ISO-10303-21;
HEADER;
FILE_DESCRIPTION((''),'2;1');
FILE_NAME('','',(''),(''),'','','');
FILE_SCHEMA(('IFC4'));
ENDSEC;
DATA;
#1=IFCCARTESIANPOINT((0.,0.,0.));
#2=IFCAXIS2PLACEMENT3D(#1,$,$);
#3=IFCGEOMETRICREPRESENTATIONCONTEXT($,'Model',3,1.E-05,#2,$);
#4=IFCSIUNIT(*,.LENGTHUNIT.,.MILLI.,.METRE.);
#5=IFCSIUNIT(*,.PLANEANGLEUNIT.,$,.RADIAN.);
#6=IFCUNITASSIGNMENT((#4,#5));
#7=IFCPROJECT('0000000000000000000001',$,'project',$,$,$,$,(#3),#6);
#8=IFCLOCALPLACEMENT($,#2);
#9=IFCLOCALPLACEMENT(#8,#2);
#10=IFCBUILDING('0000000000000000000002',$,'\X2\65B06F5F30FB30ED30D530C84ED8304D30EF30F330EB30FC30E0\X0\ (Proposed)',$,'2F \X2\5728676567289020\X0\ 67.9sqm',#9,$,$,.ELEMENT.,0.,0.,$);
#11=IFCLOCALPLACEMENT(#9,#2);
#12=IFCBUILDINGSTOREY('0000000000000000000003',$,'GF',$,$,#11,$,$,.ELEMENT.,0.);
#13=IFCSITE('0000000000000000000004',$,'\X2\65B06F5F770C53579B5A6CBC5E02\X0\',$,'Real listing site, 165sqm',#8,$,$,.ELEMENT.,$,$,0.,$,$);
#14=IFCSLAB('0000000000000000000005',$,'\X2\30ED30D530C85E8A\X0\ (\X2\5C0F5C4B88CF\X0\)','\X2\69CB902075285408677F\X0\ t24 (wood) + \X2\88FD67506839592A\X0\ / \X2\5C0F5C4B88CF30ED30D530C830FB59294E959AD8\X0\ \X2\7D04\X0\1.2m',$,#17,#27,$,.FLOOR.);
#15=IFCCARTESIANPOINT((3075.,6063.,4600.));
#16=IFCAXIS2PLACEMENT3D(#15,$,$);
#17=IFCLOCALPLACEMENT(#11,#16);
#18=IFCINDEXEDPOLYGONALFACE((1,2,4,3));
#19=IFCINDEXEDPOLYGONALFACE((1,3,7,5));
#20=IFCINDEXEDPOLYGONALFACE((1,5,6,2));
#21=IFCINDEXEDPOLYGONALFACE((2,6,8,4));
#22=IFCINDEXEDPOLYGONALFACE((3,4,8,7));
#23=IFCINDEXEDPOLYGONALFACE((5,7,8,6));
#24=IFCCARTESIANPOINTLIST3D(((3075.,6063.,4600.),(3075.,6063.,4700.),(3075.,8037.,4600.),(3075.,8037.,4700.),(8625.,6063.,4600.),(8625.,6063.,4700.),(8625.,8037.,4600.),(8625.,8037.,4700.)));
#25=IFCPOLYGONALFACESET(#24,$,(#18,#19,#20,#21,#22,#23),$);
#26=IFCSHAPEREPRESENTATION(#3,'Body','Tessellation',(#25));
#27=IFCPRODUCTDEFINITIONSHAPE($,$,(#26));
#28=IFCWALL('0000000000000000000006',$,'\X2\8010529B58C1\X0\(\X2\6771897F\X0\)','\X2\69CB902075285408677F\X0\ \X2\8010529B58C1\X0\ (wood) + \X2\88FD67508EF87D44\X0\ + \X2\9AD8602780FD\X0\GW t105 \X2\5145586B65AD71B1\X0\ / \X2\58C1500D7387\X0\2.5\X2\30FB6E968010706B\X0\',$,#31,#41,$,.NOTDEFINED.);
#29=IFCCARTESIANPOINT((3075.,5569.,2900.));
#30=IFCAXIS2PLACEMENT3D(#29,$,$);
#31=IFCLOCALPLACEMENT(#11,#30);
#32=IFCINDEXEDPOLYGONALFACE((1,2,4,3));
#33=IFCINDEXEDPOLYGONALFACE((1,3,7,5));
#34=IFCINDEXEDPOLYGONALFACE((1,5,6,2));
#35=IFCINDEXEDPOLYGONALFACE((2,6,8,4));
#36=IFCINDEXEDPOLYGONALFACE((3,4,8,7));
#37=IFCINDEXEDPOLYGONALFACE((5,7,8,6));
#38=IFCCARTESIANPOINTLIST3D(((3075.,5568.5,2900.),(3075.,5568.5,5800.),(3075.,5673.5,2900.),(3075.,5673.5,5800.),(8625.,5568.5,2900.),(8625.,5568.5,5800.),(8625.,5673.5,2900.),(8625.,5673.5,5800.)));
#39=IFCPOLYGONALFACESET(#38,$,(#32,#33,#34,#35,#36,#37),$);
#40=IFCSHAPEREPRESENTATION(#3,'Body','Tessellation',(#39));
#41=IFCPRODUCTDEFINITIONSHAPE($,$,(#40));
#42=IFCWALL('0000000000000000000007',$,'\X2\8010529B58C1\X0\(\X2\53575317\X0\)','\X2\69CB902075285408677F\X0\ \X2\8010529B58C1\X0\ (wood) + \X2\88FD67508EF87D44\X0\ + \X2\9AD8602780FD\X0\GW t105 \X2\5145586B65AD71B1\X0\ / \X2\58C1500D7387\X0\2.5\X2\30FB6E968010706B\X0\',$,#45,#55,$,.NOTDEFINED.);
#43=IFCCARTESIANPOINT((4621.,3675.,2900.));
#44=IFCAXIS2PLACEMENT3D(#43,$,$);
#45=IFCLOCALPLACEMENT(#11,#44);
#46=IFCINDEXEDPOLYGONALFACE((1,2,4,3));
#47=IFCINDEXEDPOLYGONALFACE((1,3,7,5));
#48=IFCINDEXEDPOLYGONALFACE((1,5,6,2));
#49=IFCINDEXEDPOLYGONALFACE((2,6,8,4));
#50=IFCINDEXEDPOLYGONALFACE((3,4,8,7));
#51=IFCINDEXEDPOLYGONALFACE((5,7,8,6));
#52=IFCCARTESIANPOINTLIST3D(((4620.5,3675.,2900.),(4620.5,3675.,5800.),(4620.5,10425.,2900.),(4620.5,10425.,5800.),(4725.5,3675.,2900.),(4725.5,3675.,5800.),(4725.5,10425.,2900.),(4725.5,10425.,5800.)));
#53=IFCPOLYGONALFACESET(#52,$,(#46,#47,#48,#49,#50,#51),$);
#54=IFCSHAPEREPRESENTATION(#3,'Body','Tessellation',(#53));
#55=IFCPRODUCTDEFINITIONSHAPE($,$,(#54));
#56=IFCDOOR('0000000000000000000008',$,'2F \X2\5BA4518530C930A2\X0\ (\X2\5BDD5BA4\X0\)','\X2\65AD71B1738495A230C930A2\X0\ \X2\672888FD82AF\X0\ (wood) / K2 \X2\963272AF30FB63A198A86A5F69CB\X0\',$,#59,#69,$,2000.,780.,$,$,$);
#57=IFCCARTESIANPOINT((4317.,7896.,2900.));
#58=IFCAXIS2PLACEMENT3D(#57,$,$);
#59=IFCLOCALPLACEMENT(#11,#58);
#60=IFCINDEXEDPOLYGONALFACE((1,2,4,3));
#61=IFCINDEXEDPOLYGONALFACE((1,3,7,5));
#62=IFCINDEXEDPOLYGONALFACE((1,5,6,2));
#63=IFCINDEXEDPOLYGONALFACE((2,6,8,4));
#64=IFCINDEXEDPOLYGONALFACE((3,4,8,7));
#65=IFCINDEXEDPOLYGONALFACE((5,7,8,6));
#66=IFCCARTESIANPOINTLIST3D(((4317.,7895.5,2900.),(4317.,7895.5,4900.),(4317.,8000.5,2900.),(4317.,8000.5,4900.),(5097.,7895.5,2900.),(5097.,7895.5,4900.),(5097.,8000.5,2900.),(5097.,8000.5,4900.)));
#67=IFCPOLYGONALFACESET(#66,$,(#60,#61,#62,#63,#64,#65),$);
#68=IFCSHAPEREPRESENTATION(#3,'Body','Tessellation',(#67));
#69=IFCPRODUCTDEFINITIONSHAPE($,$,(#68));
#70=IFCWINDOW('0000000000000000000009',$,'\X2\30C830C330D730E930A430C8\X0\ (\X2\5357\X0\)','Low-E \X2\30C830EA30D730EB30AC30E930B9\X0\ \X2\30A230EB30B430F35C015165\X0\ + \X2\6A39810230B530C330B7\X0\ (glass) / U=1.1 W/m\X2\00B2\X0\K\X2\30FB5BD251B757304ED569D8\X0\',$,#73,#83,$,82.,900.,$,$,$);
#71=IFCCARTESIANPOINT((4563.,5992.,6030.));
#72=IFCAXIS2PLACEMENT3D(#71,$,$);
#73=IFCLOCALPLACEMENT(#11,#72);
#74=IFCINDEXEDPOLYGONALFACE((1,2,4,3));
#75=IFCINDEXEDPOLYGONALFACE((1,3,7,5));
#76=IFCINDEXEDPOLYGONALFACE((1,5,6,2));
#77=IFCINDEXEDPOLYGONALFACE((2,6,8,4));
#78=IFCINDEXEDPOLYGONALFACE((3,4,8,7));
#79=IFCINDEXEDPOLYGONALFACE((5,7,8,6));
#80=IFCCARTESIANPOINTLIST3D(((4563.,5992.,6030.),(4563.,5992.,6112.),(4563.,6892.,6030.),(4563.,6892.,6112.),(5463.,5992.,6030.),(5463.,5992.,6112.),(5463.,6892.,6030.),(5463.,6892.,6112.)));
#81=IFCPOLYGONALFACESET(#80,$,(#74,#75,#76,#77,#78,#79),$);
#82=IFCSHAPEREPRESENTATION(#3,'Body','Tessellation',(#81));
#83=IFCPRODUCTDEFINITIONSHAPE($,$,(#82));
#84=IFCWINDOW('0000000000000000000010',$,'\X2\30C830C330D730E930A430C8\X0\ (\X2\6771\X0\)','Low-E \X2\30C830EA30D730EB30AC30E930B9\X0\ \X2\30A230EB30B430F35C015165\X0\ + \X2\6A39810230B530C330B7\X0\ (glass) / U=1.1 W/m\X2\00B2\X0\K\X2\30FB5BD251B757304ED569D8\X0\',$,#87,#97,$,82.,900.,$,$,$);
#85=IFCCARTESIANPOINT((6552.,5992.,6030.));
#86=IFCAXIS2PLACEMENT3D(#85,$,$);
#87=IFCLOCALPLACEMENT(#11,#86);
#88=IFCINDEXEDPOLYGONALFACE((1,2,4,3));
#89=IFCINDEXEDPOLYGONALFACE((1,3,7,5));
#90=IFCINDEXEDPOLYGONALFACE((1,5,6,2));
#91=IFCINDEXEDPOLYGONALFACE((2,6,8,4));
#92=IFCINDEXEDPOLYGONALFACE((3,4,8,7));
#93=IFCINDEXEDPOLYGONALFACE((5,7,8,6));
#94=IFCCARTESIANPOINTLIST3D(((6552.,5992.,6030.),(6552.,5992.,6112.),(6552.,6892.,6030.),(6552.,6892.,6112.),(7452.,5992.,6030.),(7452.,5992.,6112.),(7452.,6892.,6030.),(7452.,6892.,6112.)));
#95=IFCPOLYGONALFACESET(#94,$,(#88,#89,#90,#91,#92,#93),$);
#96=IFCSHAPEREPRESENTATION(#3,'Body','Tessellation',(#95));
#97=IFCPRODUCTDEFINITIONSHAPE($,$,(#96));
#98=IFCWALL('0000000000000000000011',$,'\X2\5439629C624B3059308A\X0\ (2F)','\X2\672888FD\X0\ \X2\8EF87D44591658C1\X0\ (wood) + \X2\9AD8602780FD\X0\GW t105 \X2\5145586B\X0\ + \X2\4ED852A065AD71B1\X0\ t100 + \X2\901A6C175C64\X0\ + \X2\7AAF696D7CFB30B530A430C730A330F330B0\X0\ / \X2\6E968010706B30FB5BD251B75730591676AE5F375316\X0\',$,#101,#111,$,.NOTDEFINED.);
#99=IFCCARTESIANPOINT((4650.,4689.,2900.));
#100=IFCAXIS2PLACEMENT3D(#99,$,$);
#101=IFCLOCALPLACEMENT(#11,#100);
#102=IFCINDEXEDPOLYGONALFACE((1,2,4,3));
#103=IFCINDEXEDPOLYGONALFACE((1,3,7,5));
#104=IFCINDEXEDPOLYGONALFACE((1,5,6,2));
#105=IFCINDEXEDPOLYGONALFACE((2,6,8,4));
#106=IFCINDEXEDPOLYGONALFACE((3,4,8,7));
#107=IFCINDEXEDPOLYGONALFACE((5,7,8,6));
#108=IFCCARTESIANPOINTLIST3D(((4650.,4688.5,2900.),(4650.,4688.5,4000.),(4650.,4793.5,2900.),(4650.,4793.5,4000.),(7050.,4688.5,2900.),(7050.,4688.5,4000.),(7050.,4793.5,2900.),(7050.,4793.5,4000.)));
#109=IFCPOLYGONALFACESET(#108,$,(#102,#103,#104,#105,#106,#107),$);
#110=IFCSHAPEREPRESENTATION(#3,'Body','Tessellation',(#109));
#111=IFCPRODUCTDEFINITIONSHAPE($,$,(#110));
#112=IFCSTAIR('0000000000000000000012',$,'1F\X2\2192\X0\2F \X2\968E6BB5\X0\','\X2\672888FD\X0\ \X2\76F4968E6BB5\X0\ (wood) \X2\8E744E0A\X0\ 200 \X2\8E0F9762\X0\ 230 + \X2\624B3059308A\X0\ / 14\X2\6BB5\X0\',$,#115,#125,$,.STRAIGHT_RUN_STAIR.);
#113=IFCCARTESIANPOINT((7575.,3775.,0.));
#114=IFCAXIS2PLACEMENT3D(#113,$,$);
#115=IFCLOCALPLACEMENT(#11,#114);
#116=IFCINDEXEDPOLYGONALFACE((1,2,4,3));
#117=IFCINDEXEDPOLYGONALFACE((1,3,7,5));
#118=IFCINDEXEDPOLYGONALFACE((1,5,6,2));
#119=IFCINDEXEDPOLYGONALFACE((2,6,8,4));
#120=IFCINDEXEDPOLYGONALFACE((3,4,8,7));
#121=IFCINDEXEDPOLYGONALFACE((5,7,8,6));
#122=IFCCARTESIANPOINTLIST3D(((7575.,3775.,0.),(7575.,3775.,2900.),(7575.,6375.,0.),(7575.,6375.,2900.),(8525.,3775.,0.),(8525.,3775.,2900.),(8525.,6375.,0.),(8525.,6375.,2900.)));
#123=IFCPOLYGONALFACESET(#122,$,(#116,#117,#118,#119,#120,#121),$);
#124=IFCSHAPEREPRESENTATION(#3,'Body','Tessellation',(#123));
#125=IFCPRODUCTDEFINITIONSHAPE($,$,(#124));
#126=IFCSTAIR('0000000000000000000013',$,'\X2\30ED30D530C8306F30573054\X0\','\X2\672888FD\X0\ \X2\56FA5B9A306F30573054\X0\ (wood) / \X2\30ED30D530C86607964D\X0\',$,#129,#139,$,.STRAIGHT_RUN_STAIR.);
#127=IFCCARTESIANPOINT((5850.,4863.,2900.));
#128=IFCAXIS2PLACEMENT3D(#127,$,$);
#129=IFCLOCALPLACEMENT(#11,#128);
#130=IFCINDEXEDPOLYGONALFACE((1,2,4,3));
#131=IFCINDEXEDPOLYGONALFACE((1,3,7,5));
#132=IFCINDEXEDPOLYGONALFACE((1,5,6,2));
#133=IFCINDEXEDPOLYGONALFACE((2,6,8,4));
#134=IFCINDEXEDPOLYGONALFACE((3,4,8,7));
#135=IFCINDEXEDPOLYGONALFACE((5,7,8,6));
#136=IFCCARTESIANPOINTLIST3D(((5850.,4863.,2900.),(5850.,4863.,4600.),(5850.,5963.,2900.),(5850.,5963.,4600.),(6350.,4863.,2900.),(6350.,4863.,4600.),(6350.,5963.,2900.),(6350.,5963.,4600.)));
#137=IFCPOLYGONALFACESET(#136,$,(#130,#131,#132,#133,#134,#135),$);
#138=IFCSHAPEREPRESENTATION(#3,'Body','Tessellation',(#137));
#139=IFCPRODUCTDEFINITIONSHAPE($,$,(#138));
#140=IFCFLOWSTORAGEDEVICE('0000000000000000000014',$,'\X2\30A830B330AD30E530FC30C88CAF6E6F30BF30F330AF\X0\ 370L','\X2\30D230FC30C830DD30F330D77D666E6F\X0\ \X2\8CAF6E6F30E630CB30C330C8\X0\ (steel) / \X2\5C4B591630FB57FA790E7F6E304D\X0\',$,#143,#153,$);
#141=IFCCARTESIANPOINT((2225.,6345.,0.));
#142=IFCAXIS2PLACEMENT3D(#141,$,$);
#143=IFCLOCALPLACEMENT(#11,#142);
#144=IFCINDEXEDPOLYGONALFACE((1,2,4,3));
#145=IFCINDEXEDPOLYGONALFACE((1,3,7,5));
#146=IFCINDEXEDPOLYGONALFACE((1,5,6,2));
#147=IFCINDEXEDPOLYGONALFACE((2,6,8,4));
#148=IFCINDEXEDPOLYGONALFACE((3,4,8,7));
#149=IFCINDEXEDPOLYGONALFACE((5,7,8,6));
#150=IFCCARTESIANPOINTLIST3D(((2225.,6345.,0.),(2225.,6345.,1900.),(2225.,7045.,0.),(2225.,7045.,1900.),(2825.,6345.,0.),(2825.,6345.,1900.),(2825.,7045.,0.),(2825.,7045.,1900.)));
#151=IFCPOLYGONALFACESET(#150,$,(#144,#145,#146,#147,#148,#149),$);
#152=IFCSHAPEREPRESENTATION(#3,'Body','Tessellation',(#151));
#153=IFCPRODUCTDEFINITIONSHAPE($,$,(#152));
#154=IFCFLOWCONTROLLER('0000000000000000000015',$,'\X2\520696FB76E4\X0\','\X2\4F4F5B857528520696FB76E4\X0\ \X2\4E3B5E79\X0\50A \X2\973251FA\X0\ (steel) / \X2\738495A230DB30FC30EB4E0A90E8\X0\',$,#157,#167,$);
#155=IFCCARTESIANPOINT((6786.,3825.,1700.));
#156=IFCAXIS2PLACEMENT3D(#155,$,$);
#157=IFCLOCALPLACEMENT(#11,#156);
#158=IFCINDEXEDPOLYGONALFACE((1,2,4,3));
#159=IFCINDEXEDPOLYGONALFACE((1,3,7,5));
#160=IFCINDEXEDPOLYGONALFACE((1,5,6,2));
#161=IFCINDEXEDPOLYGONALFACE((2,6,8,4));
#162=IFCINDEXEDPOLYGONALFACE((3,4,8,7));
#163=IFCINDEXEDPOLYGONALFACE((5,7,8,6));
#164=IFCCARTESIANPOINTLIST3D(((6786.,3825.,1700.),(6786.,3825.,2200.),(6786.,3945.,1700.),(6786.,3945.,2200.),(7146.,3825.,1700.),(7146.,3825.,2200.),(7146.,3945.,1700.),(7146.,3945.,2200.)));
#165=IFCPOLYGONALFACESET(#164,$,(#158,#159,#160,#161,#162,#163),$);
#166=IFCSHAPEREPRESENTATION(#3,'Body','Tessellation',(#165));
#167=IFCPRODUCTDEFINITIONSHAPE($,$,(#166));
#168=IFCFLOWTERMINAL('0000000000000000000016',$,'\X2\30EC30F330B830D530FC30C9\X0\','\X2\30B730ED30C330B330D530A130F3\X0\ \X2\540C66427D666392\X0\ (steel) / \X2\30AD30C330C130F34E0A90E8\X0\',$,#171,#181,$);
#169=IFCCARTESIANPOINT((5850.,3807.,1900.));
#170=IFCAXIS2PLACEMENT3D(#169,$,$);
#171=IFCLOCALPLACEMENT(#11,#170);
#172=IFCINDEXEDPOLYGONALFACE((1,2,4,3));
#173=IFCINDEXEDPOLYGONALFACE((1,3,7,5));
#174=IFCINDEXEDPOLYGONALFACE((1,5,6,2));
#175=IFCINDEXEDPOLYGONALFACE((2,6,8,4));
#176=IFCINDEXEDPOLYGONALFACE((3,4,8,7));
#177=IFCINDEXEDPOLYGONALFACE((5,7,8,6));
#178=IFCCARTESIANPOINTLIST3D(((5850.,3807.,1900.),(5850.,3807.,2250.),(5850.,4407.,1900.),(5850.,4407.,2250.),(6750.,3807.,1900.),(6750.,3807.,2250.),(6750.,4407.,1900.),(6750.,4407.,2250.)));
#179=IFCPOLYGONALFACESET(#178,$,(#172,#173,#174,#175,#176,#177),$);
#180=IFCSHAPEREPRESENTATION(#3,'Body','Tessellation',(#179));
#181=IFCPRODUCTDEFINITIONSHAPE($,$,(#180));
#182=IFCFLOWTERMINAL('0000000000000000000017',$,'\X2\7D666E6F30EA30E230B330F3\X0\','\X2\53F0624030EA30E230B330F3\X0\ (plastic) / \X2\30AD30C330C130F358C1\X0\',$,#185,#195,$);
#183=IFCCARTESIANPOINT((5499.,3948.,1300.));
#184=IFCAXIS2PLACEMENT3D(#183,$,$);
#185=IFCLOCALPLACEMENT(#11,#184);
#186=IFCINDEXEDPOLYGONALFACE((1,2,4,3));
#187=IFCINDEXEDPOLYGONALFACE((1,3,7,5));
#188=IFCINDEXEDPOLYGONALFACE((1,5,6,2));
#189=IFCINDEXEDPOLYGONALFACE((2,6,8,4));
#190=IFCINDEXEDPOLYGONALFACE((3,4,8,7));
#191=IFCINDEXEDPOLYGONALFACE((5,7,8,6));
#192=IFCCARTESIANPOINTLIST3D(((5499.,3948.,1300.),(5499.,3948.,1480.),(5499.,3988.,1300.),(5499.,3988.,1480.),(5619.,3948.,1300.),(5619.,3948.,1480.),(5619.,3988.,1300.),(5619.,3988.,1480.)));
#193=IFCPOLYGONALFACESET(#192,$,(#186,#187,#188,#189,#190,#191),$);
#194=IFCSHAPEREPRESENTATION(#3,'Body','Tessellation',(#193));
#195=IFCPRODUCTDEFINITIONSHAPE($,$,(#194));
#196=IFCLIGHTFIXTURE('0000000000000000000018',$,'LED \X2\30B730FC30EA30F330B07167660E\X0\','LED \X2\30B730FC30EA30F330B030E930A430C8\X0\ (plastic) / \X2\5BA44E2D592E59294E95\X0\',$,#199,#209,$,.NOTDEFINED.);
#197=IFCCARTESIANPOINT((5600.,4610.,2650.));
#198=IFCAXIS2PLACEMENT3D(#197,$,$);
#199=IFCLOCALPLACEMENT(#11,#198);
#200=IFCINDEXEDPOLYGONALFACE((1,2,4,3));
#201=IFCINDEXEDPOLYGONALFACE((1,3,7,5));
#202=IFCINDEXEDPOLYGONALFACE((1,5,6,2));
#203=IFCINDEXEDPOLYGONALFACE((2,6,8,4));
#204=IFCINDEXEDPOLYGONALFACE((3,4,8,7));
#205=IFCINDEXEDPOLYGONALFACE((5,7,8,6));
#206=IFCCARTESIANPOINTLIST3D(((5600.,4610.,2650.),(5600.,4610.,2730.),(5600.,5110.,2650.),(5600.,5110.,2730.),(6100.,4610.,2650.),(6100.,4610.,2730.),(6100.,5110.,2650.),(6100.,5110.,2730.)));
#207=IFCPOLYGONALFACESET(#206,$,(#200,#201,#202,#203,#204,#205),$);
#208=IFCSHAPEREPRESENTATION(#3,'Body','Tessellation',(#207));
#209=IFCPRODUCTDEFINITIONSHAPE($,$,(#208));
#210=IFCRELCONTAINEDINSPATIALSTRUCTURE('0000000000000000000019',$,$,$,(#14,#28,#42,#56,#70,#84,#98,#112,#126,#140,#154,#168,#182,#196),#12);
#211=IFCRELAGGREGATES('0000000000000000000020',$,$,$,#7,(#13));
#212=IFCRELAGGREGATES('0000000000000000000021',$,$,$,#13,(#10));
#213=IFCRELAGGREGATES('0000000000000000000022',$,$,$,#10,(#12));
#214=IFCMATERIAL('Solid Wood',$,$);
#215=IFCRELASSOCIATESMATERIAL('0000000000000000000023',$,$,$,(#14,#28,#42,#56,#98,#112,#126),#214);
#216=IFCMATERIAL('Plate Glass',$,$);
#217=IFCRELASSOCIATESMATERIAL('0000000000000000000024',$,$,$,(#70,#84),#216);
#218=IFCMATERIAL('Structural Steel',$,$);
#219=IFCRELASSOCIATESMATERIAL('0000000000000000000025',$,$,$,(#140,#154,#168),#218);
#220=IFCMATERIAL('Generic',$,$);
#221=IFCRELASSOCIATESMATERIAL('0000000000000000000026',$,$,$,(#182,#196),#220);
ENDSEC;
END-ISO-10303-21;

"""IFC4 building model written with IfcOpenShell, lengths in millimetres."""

from ifc_helpers import new_model, si_unit, frame, frame_2d, origin, place, context, project, spatial, rectangle, extrude, material, element, fill, save


model = new_model("IFC4")

# Units and contexts
model_context = context("Model", 3, precision=1e-05, world=origin())
ifc_project = project(units=[si_unit("LENGTHUNIT", "METRE", prefix="MILLI"), si_unit("PLANEANGLEUNIT", "RADIAN")], contexts=[model_context])

# Site, building, storey
site_placement = place(None, origin())
site = spatial("IfcSite", under=ifc_project, at=site_placement, Name="新潟県南魚沼市", ObjectType="Real listing site, 165sqm", CompositionType="ELEMENT", RefElevation=0.0)
building_placement = place(site_placement, origin())
building = spatial("IfcBuilding", under=site, at=building_placement, Name="新潟・ロフト付きワンルーム (Proposed)", ObjectType="2F 在来木造 67.9sqm", CompositionType="ELEMENT", ElevationOfRefHeight=0.0, ElevationOfTerrain=0.0)
storey_placement = place(building_placement, origin())
storey = spatial("IfcBuildingStorey", under=building, at=storey_placement, Name="GF", CompositionType="ELEMENT", Elevation=0.0)

# Shared definitions
ifc_material_1 = material(Name="Solid Wood")

# Slab
slab_placement = place(storey_placement, frame((3075.0, 6063.0, 4600.0)))
element("IfcSlab", 1, at=slab_placement, inside=storey, material=ifc_material_1, Name="ロフト床 (小屋裏)", Description="構造用合板 t24 (wood) + 製材根太 / 小屋裏ロフト・天井高 約1.2m", PredefinedType="FLOOR", context=model_context, shape_type="SweptSolid", body=[
    extrude(rectangle(XDim=5550.0, YDim=1974.0, at=frame_2d((2775.0, 987.0))), frame((3075.0, 6063.0, 4600.0)), (0.0, 0.0, 1.0), 100.0),
])

# Wall
wall_1_placement = place(storey_placement, frame((3075.0, 5569.0, 2900.0)))
element("IfcWall", 2, at=wall_1_placement, inside=storey, material=ifc_material_1, Name="耐力壁(東西)", Description="構造用合板 耐力壁 (wood) + 製材軸組 + 高性能GW t105 充填断熱 / 壁倍率2.5・準耐火", PredefinedType="NOTDEFINED", context=model_context, shape_type="SweptSolid", body=[
    extrude(rectangle(XDim=5550.0, YDim=105.0, at=frame_2d((2775.0, 52.0))), frame((3075.0, 5569.0, 2900.0)), (0.0, 0.0, 1.0), 2900.0),
])

# Wall, opening, door
wall_2_placement = place(storey_placement, frame((4621.0, 3675.0, 2900.0)))
wall_2 = element("IfcWall", 3, at=wall_2_placement, inside=storey, material=ifc_material_1, Name="耐力壁(南北)", Description="構造用合板 耐力壁 (wood) + 製材軸組 + 高性能GW t105 充填断熱 / 壁倍率2.5・準耐火", PredefinedType="NOTDEFINED", context=model_context, shape_type="SweptSolid", body=[
    extrude(rectangle(XDim=105.0, YDim=6750.0, at=frame_2d((52.0, 3375.0))), frame((4621.0, 3675.0, 2900.0)), (0.0, 0.0, 1.0), 2900.0),
])
opening_placement = place(storey_placement, frame((4317.0, 7896.0, 2900.0)))
opening = element("IfcOpeningElement", 4, at=opening_placement, cuts=wall_2, PredefinedType="NOTDEFINED", context=model_context, shape_type="SweptSolid", body=[
    extrude(rectangle(XDim=780.0, YDim=105.0, at=frame_2d((390.0, 52.0))), frame((4317.0, 7896.0, 2900.0)), (0.0, 0.0, 1.0), 2000.0),
])
door_placement = place(storey_placement, frame((4317.0, 7896.0, 2900.0)))
door = element("IfcDoor", 5, at=door_placement, inside=storey, material=ifc_material_1, Name="2F 室内ドア (寝室)", Description="断熱玄関ドア 木製芯 (wood) / K2 防犯・採風機構", OverallHeight=2000.0, OverallWidth=780.0, context=model_context, shape_type="SweptSolid", body=[
    extrude(rectangle(XDim=780.0, YDim=105.0, at=frame_2d((390.0, 52.0))), frame((4317.0, 7896.0, 2900.0)), (0.0, 0.0, 1.0), 2000.0),
])
fill(opening, door)

# Windows
ifc_material_2 = material(Name="Plate Glass")
window_1_placement = place(storey_placement, frame((4563.0, 5992.0, 6030.0)))
element("IfcWindow", 6, at=window_1_placement, inside=storey, material=ifc_material_2, Name="トップライト (南)", Description="Low-E トリプルガラス アルゴン封入 + 樹脂サッシ (glass) / U=1.1 W/m²K・寒冷地仕様", OverallHeight=82.0, OverallWidth=900.0, context=model_context, shape_type="SweptSolid", body=[
    extrude(rectangle(XDim=900.0, YDim=900.0, at=frame_2d((450.0, 450.0))), frame((4563.0, 5992.0, 6030.0)), (0.0, 0.0, 1.0), 82.0),
])
window_2_placement = place(storey_placement, frame((6552.0, 5992.0, 6030.0)))
element("IfcWindow", 7, at=window_2_placement, inside=storey, material=ifc_material_2, Name="トップライト (東)", Description="Low-E トリプルガラス アルゴン封入 + 樹脂サッシ (glass) / U=1.1 W/m²K・寒冷地仕様", OverallHeight=82.0, OverallWidth=900.0, context=model_context, shape_type="SweptSolid", body=[
    extrude(rectangle(XDim=900.0, YDim=900.0, at=frame_2d((450.0, 450.0))), frame((6552.0, 5992.0, 6030.0)), (0.0, 0.0, 1.0), 82.0),
])

# Wall
wall_3_placement = place(storey_placement, frame((4650.0, 4689.0, 2900.0)))
element("IfcWall", 8, at=wall_3_placement, inside=storey, material=ifc_material_1, Name="吹抜手すり (2F)", Description="木製 軸組外壁 (wood) + 高性能GW t105 充填 + 付加断熱 t100 + 通気層 + 窯業系サイディング / 準耐火・寒冷地外皮強化", PredefinedType="NOTDEFINED", context=model_context, shape_type="SweptSolid", body=[
    extrude(rectangle(XDim=2400.0, YDim=105.0, at=frame_2d((1200.0, 52.0))), frame((4650.0, 4689.0, 2900.0)), (0.0, 0.0, 1.0), 1100.0),
])

# Stairs
stair_1_placement = place(storey_placement, frame((7575.0, 3775.0, 0.0)))
element("IfcStair", 9, at=stair_1_placement, inside=storey, material=ifc_material_1, Name="1F→2F 階段", Description="木製 直階段 (wood) 蹴上 200 踏面 230 + 手すり / 14段", PredefinedType="STRAIGHT_RUN_STAIR", context=model_context, shape_type="SweptSolid", body=[
    extrude(rectangle(XDim=950.0, YDim=2600.0, at=frame_2d((475.0, 1300.0))), frame((7575.0, 3775.0, 0.0)), (0.0, 0.0, 1.0), 2900.0),
])
stair_2_placement = place(storey_placement, frame((5850.0, 4863.0, 2900.0)))
element("IfcStair", 10, at=stair_2_placement, inside=storey, material=ifc_material_1, Name="ロフトはしご", Description="木製 固定はしご (wood) / ロフト昇降", PredefinedType="STRAIGHT_RUN_STAIR", context=model_context, shape_type="SweptSolid", body=[
    extrude(rectangle(XDim=500.0, YDim=1100.0, at=frame_2d((250.0, 550.0))), frame((5850.0, 4863.0, 2900.0)), (0.0, 0.0, 1.0), 1700.0),
])

# Flow storage device
ifc_material_3 = material(Name="Structural Steel")
flow_storage_device_placement = place(storey_placement, frame((2225.0, 6345.0, 0.0)))
element("IfcFlowStorageDevice", 11, at=flow_storage_device_placement, inside=storey, material=ifc_material_3, Name="エコキュート貯湯タンク 370L", Description="ヒートポンプ給湯 貯湯ユニット (steel) / 屋外・基礎置き", context=model_context, shape_type="SweptSolid", body=[
    extrude(rectangle(XDim=600.0, YDim=700.0, at=frame_2d((300.0, 350.0))), frame((2225.0, 6345.0, 0.0)), (0.0, 0.0, 1.0), 1900.0),
])

# Flow controller
flow_controller_placement = place(storey_placement, frame((6786.0, 3825.0, 1700.0)))
element("IfcFlowController", 12, at=flow_controller_placement, inside=storey, material=ifc_material_3, Name="分電盤", Description="住宅用分電盤 主幹50A 露出 (steel) / 玄関ホール上部", context=model_context, shape_type="SweptSolid", body=[
    extrude(rectangle(XDim=360.0, YDim=120.0, at=frame_2d((180.0, 60.0))), frame((6786.0, 3825.0, 1700.0)), (0.0, 0.0, 1.0), 500.0),
])

# Flow terminals
flow_terminal_1_placement = place(storey_placement, frame((5850.0, 3807.0, 1900.0)))
element("IfcFlowTerminal", 13, at=flow_terminal_1_placement, inside=storey, material=ifc_material_3, Name="レンジフード", Description="シロッコファン 同時給排 (steel) / キッチン上部", context=model_context, shape_type="SweptSolid", body=[
    extrude(rectangle(XDim=900.0, YDim=600.0, at=frame_2d((450.0, 300.0))), frame((5850.0, 3807.0, 1900.0)), (0.0, 0.0, 1.0), 350.0),
])
ifc_material_4 = material(Name="Generic")
flow_terminal_2_placement = place(storey_placement, frame((5499.0, 3948.0, 1300.0)))
element("IfcFlowTerminal", 14, at=flow_terminal_2_placement, inside=storey, material=ifc_material_4, Name="給湯リモコン", Description="台所リモコン (plastic) / キッチン壁", context=model_context, shape_type="SweptSolid", body=[
    extrude(rectangle(XDim=120.0, YDim=40.0, at=frame_2d((60.0, 20.0))), frame((5499.0, 3948.0, 1300.0)), (0.0, 0.0, 1.0), 180.0),
])

# Light fixture
light_fixture_1_placement = place(storey_placement, frame((5600.0, 4610.0, 2650.0)))
element("IfcLightFixture", 15, at=light_fixture_1_placement, inside=storey, material=ifc_material_4, Name="LED シーリング照明", Description="LED シーリングライト (plastic) / 室中央天井", PredefinedType="NOTDEFINED", context=model_context, shape_type="SweptSolid", body=[
    extrude(rectangle(XDim=500.0, YDim=500.0, at=frame_2d((250.0, 250.0))), frame((5600.0, 4610.0, 2650.0)), (0.0, 0.0, 1.0), 80.0),
])

save(model, "model.ifc")
